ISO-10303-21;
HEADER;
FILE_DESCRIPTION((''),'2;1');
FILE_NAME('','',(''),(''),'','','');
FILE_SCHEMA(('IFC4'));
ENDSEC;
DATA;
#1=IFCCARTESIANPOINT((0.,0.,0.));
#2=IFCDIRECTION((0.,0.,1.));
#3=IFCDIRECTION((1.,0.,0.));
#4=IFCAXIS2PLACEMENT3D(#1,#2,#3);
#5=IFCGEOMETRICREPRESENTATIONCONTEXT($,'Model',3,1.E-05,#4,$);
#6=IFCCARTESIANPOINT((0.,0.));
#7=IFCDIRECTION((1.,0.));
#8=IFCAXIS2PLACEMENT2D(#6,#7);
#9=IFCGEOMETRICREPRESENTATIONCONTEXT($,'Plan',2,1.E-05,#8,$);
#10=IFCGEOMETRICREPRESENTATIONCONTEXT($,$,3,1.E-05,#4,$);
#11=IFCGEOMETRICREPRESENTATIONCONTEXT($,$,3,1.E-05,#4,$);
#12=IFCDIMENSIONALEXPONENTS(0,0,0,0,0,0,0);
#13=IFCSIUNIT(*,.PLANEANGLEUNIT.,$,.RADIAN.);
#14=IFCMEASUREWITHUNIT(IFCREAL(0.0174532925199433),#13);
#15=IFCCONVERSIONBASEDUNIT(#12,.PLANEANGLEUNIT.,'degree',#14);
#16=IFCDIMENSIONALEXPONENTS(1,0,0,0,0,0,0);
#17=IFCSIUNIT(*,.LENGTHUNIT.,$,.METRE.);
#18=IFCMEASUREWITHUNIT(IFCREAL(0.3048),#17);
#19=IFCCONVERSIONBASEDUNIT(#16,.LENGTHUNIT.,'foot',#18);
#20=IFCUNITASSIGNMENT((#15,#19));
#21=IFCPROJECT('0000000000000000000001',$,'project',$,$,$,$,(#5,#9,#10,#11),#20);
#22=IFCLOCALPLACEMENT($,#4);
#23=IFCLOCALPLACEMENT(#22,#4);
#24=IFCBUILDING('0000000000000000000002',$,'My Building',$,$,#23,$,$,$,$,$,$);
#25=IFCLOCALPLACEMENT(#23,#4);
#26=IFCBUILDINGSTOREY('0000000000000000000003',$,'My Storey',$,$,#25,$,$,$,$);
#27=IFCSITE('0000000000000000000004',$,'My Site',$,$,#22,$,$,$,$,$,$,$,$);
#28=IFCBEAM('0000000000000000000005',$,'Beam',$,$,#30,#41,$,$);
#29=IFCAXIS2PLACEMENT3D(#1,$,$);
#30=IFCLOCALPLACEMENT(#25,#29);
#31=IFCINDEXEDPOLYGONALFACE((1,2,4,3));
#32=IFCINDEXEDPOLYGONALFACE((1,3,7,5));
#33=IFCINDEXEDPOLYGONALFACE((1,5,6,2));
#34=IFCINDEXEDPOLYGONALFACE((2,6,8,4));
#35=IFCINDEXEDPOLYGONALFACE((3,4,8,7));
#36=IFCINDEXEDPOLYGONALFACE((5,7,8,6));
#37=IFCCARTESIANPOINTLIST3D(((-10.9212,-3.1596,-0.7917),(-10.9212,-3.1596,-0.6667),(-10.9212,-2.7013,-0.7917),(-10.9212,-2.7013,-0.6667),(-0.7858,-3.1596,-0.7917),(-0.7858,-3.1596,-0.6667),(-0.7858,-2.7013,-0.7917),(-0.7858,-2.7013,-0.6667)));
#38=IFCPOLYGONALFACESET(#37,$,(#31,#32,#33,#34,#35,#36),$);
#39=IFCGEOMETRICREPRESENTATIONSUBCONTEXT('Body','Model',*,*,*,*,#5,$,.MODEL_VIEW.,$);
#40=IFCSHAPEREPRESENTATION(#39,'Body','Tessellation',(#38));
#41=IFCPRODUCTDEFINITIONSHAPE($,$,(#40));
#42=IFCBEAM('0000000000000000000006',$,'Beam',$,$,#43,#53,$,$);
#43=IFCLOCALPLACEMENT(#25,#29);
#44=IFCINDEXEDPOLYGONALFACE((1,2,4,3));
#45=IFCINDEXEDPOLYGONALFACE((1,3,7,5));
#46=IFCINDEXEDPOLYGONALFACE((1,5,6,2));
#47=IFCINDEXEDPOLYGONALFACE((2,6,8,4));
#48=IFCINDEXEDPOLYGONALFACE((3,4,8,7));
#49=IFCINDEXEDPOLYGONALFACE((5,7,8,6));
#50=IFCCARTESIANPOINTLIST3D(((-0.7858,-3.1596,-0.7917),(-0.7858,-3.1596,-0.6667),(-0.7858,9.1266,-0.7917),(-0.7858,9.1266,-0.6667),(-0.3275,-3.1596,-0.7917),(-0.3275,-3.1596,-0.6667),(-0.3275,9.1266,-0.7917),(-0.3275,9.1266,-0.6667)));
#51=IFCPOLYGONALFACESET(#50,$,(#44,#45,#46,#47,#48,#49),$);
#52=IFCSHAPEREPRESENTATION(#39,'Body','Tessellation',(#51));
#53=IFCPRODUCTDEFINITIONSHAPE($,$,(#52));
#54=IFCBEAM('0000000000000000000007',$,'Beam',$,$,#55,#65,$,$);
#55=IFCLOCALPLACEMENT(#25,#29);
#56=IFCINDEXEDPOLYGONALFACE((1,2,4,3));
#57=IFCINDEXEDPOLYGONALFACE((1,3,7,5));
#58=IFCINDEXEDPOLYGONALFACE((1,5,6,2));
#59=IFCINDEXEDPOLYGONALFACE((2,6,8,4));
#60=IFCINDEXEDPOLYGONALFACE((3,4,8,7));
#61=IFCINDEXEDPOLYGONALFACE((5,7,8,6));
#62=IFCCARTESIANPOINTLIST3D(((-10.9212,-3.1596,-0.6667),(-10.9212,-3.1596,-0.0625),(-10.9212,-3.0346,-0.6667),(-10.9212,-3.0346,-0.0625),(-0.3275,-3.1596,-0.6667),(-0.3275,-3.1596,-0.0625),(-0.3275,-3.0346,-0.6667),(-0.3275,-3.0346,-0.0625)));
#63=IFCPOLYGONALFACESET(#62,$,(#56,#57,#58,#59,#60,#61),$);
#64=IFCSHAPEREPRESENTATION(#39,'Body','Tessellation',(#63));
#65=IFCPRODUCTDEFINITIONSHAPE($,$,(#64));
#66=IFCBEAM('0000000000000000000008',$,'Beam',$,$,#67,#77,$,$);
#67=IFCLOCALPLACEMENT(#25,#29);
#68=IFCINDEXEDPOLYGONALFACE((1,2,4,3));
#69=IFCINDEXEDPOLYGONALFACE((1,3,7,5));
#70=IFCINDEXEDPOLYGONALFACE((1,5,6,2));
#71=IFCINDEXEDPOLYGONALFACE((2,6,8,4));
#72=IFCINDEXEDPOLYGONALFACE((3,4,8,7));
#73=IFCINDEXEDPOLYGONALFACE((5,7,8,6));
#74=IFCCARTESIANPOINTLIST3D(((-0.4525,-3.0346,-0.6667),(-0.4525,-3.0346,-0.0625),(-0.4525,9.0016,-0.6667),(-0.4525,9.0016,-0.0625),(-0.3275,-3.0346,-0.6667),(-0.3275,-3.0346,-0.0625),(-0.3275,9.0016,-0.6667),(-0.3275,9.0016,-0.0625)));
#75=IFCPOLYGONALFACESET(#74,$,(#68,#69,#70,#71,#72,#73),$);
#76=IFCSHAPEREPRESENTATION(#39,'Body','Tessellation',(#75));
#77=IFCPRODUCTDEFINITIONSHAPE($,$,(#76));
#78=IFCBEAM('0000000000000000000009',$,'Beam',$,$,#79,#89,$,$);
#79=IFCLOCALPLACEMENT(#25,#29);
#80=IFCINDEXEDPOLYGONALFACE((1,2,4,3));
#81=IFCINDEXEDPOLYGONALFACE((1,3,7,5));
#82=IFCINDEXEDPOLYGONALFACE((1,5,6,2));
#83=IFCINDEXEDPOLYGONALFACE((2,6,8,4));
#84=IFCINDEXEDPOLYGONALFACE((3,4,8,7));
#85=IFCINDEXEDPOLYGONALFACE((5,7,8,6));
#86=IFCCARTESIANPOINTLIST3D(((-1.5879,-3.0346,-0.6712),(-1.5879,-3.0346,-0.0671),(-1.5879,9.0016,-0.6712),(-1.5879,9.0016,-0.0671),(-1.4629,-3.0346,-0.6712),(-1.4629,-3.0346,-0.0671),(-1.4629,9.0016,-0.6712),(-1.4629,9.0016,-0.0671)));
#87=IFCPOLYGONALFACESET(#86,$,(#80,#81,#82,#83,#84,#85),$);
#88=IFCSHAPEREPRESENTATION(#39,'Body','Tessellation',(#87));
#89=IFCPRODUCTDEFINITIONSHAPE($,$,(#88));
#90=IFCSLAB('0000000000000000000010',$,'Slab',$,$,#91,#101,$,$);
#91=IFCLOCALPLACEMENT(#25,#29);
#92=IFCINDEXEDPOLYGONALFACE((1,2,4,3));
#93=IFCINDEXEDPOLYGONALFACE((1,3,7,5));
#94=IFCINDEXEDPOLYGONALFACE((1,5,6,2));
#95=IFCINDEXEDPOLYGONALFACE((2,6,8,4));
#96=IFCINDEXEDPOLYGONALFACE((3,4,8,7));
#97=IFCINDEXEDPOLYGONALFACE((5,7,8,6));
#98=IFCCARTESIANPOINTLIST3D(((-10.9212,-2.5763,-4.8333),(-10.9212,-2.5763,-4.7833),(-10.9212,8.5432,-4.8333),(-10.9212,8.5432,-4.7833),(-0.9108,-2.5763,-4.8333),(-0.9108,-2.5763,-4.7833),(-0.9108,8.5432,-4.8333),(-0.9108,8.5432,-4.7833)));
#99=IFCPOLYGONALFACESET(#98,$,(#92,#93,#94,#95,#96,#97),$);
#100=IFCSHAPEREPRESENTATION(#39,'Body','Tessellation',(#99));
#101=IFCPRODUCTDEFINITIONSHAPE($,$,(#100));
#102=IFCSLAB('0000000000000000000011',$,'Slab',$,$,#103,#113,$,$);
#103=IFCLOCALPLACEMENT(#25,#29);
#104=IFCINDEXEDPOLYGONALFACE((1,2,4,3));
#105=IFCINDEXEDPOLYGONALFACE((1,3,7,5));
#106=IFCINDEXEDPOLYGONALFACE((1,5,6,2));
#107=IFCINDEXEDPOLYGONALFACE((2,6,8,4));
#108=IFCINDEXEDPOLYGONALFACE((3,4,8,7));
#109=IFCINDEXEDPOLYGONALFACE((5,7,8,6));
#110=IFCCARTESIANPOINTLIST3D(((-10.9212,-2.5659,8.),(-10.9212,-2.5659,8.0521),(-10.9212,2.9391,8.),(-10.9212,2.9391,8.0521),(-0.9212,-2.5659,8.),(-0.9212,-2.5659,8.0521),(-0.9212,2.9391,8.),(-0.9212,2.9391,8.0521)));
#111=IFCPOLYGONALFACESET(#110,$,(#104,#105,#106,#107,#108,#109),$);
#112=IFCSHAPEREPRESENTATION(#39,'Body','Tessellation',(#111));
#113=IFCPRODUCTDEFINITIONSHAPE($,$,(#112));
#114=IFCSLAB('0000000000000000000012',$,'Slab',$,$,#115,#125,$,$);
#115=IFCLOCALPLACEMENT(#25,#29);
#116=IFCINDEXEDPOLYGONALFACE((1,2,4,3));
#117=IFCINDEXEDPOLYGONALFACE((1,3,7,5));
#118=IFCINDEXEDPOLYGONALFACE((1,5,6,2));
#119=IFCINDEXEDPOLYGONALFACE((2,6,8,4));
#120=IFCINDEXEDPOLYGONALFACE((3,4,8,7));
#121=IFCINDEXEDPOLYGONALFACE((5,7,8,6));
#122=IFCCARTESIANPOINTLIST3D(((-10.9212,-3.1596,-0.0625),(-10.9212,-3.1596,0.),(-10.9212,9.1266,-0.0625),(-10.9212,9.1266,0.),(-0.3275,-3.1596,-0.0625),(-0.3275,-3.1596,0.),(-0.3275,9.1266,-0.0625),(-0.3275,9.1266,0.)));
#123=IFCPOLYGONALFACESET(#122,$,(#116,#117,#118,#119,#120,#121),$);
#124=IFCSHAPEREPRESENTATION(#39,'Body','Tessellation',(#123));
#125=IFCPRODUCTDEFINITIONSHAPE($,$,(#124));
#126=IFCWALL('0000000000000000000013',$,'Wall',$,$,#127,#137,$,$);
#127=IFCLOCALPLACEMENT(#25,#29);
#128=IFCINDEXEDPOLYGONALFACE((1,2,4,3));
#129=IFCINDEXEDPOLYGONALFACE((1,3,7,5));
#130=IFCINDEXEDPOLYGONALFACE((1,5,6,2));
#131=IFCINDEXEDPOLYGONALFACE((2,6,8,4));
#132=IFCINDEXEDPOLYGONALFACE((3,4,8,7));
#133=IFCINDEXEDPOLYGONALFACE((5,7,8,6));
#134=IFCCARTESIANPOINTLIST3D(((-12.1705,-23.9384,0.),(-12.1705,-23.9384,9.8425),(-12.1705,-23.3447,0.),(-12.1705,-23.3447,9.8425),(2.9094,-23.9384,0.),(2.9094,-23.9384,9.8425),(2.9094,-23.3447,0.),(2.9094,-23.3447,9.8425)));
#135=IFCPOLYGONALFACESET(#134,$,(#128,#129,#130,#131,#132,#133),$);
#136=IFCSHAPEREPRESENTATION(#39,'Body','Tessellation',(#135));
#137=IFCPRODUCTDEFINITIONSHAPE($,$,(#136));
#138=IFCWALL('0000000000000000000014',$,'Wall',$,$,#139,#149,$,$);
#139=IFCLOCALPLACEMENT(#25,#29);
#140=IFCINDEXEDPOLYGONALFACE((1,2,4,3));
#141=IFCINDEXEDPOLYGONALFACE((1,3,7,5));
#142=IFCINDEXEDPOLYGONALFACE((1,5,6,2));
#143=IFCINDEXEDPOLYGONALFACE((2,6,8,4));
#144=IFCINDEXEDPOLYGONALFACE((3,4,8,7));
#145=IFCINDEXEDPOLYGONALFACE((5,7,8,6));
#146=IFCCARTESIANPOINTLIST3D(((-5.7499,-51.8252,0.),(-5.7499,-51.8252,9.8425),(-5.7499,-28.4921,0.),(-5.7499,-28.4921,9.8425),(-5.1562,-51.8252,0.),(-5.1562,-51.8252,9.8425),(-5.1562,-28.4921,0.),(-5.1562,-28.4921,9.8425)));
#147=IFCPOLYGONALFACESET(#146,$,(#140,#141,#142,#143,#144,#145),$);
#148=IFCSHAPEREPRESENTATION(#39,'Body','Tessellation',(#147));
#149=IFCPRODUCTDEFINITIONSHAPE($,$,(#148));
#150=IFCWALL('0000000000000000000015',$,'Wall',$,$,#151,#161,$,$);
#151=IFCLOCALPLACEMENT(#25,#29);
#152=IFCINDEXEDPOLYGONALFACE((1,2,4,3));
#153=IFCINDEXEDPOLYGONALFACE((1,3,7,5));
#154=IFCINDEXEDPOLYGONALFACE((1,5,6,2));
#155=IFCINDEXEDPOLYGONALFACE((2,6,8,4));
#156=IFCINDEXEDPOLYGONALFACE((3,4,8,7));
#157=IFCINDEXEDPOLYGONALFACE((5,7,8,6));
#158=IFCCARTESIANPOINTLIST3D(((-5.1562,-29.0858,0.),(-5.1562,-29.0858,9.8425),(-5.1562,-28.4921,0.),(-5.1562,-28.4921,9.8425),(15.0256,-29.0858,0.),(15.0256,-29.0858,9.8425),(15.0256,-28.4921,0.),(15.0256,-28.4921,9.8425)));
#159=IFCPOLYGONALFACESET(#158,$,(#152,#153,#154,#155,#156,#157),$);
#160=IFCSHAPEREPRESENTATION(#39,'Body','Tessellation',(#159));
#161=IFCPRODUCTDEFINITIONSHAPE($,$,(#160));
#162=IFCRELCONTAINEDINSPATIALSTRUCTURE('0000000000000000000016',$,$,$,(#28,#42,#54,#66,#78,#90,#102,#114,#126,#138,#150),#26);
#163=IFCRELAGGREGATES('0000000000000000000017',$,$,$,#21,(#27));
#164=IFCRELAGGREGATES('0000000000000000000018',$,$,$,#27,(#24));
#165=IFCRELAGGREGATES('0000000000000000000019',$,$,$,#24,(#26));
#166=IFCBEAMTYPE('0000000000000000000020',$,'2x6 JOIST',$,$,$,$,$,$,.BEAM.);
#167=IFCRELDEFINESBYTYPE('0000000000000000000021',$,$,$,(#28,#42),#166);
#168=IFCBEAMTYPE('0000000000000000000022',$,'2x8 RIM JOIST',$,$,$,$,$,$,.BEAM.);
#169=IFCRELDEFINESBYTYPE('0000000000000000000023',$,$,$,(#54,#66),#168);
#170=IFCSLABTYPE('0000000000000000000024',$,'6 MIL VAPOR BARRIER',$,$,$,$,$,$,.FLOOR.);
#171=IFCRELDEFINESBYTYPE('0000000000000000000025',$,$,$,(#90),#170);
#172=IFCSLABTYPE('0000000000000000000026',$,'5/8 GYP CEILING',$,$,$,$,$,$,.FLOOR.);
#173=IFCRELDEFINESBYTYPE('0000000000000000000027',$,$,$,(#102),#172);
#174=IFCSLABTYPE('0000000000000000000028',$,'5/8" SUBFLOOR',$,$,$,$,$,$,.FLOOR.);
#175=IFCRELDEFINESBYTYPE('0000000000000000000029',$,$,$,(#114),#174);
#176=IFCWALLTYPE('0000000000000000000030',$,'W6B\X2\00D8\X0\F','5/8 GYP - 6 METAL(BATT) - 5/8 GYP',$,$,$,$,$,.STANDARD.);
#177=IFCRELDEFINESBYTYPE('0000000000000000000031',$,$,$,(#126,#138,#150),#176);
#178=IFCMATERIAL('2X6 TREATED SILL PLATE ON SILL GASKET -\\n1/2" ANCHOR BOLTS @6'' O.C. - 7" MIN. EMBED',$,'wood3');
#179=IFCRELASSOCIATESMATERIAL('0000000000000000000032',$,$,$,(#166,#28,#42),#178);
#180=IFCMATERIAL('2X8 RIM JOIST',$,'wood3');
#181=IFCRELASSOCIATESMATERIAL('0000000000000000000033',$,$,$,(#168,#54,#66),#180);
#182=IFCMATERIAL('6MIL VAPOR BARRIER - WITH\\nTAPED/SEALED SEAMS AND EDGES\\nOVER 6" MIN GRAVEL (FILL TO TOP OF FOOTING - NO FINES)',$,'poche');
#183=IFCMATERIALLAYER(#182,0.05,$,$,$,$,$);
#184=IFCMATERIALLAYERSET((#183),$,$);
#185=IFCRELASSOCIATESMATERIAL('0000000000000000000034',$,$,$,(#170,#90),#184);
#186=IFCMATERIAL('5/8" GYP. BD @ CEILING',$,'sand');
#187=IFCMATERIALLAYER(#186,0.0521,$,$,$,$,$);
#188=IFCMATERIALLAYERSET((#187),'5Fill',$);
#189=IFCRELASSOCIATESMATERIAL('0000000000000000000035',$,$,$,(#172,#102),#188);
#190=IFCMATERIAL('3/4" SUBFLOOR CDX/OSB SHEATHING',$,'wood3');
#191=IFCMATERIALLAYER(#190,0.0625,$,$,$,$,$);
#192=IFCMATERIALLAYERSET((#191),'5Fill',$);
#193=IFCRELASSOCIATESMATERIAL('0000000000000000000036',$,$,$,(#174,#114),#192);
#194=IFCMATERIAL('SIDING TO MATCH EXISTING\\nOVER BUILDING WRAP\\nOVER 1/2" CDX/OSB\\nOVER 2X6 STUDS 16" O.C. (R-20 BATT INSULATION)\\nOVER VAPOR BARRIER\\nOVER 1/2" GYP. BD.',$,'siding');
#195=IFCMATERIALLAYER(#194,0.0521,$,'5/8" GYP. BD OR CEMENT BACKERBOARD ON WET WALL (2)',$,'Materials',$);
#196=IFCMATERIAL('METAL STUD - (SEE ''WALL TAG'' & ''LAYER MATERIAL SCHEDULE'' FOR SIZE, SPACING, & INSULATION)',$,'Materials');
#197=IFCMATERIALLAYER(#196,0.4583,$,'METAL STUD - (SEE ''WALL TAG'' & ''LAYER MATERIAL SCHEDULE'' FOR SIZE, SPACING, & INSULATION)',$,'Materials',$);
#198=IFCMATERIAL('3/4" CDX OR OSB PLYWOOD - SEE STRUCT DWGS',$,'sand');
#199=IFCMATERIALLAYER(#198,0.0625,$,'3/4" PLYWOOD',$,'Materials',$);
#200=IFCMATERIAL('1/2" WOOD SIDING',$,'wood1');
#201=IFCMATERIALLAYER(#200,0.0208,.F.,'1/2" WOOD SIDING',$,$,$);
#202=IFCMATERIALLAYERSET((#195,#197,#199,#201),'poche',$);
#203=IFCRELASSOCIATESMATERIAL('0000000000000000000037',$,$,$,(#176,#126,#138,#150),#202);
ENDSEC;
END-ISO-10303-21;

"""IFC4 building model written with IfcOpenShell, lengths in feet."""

from ifc_helpers import new_model, entity, si_unit, converted_unit, frame, origin_with_axes, origin_2d_with_axis, place, context, subcontext, project, spatial, line, indexed_curve, rectangle, outline, extrude, material, layer, layer_set, layer_usage, material_profile, profile_set, profile_usage, type_object, element, save


model = new_model("IFC4")

# Units and contexts
model_context = context("Model", 3, precision=1e-05, world=origin_with_axes())
plan_context = context("Plan", 2, precision=1e-05, world=origin_2d_with_axis())
context_of_model_1 = context(None, 3, precision=1e-05, world=origin_with_axes())
context_of_model_2 = context(None, 3, precision=1e-05, world=origin_with_axes())
body_context = subcontext(model_context, "Body", "Model", "MODEL_VIEW")
ifc_project = project(units=[converted_unit("PLANEANGLEUNIT", "degree", entity("IfcReal", 0.0174532925199433), si_unit("PLANEANGLEUNIT", "RADIAN"), dimensions=[0, 0, 0, 0, 0, 0, 0]), converted_unit("LENGTHUNIT", "foot", entity("IfcReal", 0.3048), si_unit("LENGTHUNIT", "METRE"), dimensions=[1, 0, 0, 0, 0, 0, 0])], contexts=[model_context, plan_context, context_of_model_1, context_of_model_2])

# Site, building, storey
site_placement = place(None, origin_with_axes())
site = spatial("IfcSite", under=ifc_project, at=site_placement, Name="My Site")
building_placement = place(site_placement, origin_with_axes())
building = spatial("IfcBuilding", under=site, at=building_placement, Name="My Building")
storey_placement = place(building_placement, origin_with_axes())
storey = spatial("IfcBuildingStorey", under=building, at=storey_placement, Name="My Storey")

# Beams
ifc_material_1 = material(Name="2X6 TREATED SILL PLATE ON SILL GASKET -\\n1/2\" ANCHOR BOLTS @6' O.C. - 7\" MIN. EMBED", Category="wood3")
ifc_material_profile_1 = material_profile(ifc_material_1, rectangle(XDim=0.125, YDim=0.4583))
ifc_profile_set_1 = profile_set([ifc_material_profile_1])
ifc_profile_usage_1 = profile_usage(ifc_profile_set_1, cardinal=5)
beam_type_1 = type_object("IfcBeamType", Name="2x6 JOIST", PredefinedType="BEAM", material=ifc_profile_set_1)
beam_1_placement = place(storey_placement, frame((-10.9212, -2.9304, -0.7292), z_axis=(1.0, 0.0, 0.0), x_axis=(0.0, 0.0, 1.0)))
element("IfcBeam", 1, at=beam_1_placement, inside=storey, type_object=beam_type_1, material=ifc_profile_usage_1, Name="Beam", context=body_context, shape_type="SweptSolid", body=[
    extrude(rectangle(XDim=0.125, YDim=0.4583), origin_with_axes(), (0.0, 0.0, 1.0), 10.1354),
])
ifc_profile_usage_2 = profile_usage(ifc_profile_set_1, cardinal=5)
beam_2_placement = place(storey_placement, frame((-0.5566, -3.1596, -0.7292), z_axis=(0.0, 1.0, 0.0), x_axis=(0.0, 0.0, 1.0)))
element("IfcBeam", 2, at=beam_2_placement, inside=storey, type_object=beam_type_1, material=ifc_profile_usage_2, Name="Beam", context=body_context, shape_type="SweptSolid", body=[
    extrude(rectangle(XDim=0.125, YDim=0.4583), origin_with_axes(), (0.0, 0.0, 1.0), 12.2862),
])
ifc_material_2 = material(Name="2X8 RIM JOIST", Category="wood3")
ifc_material_profile_2 = material_profile(ifc_material_2, rectangle(XDim=0.125, YDim=0.6042))
ifc_profile_set_2 = profile_set([ifc_material_profile_2])
ifc_profile_usage_3 = profile_usage(ifc_profile_set_2)
beam_type_2 = type_object("IfcBeamType", Name="2x8 RIM JOIST", PredefinedType="BEAM", material=ifc_profile_set_2)
beam_3_placement = place(storey_placement, frame((-10.9212, -3.0971, -0.3646), z_axis=(1.0, 0.0, 0.0), x_axis=(0.0, 1.0, 0.0)))
element("IfcBeam", 3, at=beam_3_placement, inside=storey, type_object=beam_type_2, material=ifc_profile_usage_3, Name="Beam", context=body_context, shape_type="SweptSolid", body=[
    extrude(rectangle(XDim=0.125, YDim=0.6042), origin_with_axes(), (0.0, 0.0, 1.0), 10.5937),
])
ifc_profile_usage_4 = profile_usage(ifc_profile_set_2)
beam_4_placement = place(storey_placement, frame((-0.39, -3.0346, -0.3646), z_axis=(0.0, 1.0, 0.0), x_axis=(-1.0, 0.0, 0.0)))
element("IfcBeam", 4, at=beam_4_placement, inside=storey, type_object=beam_type_2, material=ifc_profile_usage_4, Name="Beam", context=body_context, shape_type="SweptSolid", body=[
    extrude(rectangle(XDim=0.125, YDim=0.6042), origin_with_axes(), (0.0, 0.0, 1.0), 12.0362),
])
beam_5_placement = place(storey_placement, frame((-1.5254, -3.0346, -0.3692), z_axis=(0.0, 1.0, 0.0), x_axis=(-1.0, 0.0, 0.0)))
element("IfcBeam", 5, at=beam_5_placement, inside=storey, Name="Beam", context=body_context, shape_type="SweptSolid", body=[
    extrude(rectangle(XDim=0.125, YDim=0.6042), origin_with_axes(), (0.0, 0.0, 1.0), 12.0362),
])

# Slabs
ifc_material_3 = material(Name="6MIL VAPOR BARRIER - WITH\\nTAPED/SEALED SEAMS AND EDGES\\nOVER 6\" MIN GRAVEL (FILL TO TOP OF FOOTING - NO FINES)", Category="poche")
ifc_layer_1 = layer(ifc_material_3, 0.05)
ifc_layer_set_1 = layer_set([ifc_layer_1])
ifc_layer_usage_1 = layer_usage(ifc_layer_set_1, "AXIS3", "POSITIVE", 0.0)
slab_type_1 = type_object("IfcSlabType", Name="6 MIL VAPOR BARRIER", PredefinedType="FLOOR", material=ifc_layer_set_1)
slab_1_placement = place(storey_placement, frame((-10.9212, -2.5763, -4.8333), z_axis=(0.0, 0.0, 1.0), x_axis=(1.0, 0.0, 0.0)))
element("IfcSlab", 6, at=slab_1_placement, inside=storey, type_object=slab_type_1, material=ifc_layer_usage_1, Name="Slab", context=body_context, shape_type="SweptSolid", body=[
    extrude(outline(indexed_curve([(10.0104, 11.1195), (10.0104, 0.0), (0.0, 0.0), (0.0, 11.1195)], segments=[line(3, 2), line(2, 1), line(1, 4), line(4, 3)], self_intersect=False)), None, (0.0, 0.0, 1.0), 0.05),
])
ifc_material_4 = material(Name="5/8\" GYP. BD @ CEILING", Category="sand")
ifc_layer_2 = layer(ifc_material_4, 0.0521)
ifc_layer_set_2 = layer_set([ifc_layer_2], Name="5Fill")
ifc_layer_usage_2 = layer_usage(ifc_layer_set_2, "AXIS3", "POSITIVE", 0.0)
slab_type_2 = type_object("IfcSlabType", Name="5/8 GYP CEILING", PredefinedType="FLOOR", material=ifc_layer_set_2)
slab_2_placement = place(storey_placement, frame((-10.9212, -2.5659, 8.0), z_axis=(0.0, 0.0, 1.0), x_axis=(1.0, 0.0, 0.0)))
element("IfcSlab", 7, at=slab_2_placement, inside=storey, type_object=slab_type_2, material=ifc_layer_usage_2, Name="Slab", context=body_context, shape_type="SweptSolid", body=[
    extrude(outline(indexed_curve([(0.0, 5.505), (0.0, 0.0), (10.0, 0.0), (10.0, 5.505)], segments=[line(3, 2), line(2, 1), line(1, 4), line(4, 3)], self_intersect=False)), None, (0.0, 0.0, 1.0), 0.0521),
])
ifc_material_5 = material(Name="3/4\" SUBFLOOR CDX/OSB SHEATHING", Category="wood3")
ifc_layer_3 = layer(ifc_material_5, 0.0625)
ifc_layer_set_3 = layer_set([ifc_layer_3], Name="5Fill")
ifc_layer_usage_3 = layer_usage(ifc_layer_set_3, "AXIS3", "POSITIVE", 0.0)
slab_type_3 = type_object("IfcSlabType", Name="5/8\" SUBFLOOR", PredefinedType="FLOOR", material=ifc_layer_set_3)
slab_3_placement = place(storey_placement, frame((-10.9212, -3.1596, -0.0625), z_axis=(0.0, 0.0, 1.0), x_axis=(1.0, 0.0, 0.0)))
element("IfcSlab", 8, at=slab_3_placement, inside=storey, type_object=slab_type_3, material=ifc_layer_usage_3, Name="Slab", context=body_context, shape_type="SweptSolid", body=[
    extrude(outline(indexed_curve([(0.0, 0.0), (10.5937, 0.0), (10.5937, 12.2862), (0.0, 12.2862)], segments=[line(3, 2), line(2, 1), line(1, 4), line(4, 3)], self_intersect=False)), None, (0.0, 0.0, 1.0), 0.0625),
])

# Shared definitions
ifc_material_6 = material(Name="SIDING TO MATCH EXISTING\\nOVER BUILDING WRAP\\nOVER 1/2\" CDX/OSB\\nOVER 2X6 STUDS 16\" O.C. (R-20 BATT INSULATION)\\nOVER VAPOR BARRIER\\nOVER 1/2\" GYP. BD.", Category="siding")
ifc_layer_4 = layer(ifc_material_6, 0.0521, Name="5/8\" GYP. BD OR CEMENT BACKERBOARD ON WET WALL (2)", Category="Materials")
ifc_material_7 = material(Name="METAL STUD - (SEE 'WALL TAG' & 'LAYER MATERIAL SCHEDULE' FOR SIZE, SPACING, & INSULATION)", Category="Materials")
ifc_layer_5 = layer(ifc_material_7, 0.4583, Name="METAL STUD - (SEE 'WALL TAG' & 'LAYER MATERIAL SCHEDULE' FOR SIZE, SPACING, & INSULATION)", Category="Materials")
ifc_material_8 = material(Name="3/4\" CDX OR OSB PLYWOOD - SEE STRUCT DWGS", Category="sand")
ifc_layer_6 = layer(ifc_material_8, 0.0625, Name="3/4\" PLYWOOD", Category="Materials")
ifc_material_9 = material(Name="1/2\" WOOD SIDING", Category="wood1")
ifc_layer_7 = layer(ifc_material_9, 0.0208, ventilated=False, Name="1/2\" WOOD SIDING")
ifc_layer_set_4 = layer_set([ifc_layer_4, ifc_layer_5, ifc_layer_6, ifc_layer_7], Name="poche")
wall_type_1 = type_object("IfcWallType", Name="W6BØF", Description="5/8 GYP - 6 METAL(BATT) - 5/8 GYP", PredefinedType="STANDARD", material=ifc_layer_set_4)

# Walls
ifc_layer_usage_4 = layer_usage(ifc_layer_set_4, "AXIS2", "POSITIVE", 0.0)
wall_1_placement = place(storey_placement, frame((2.9094, -23.3447, 0.0), z_axis=(0.0, 0.0, 1.0), x_axis=(-1.0, 0.0, 0.0)))
element("IfcWall", 9, at=wall_1_placement, inside=storey, type_object=wall_type_1, material=ifc_layer_usage_4, Name="Wall", context=body_context, shape_type="SweptSolid", body=[
    extrude(outline(indexed_curve([(0.0, 0.0), (0.0, 0.5937), (15.0799, 0.5937), (15.0799, 0.0), (0.0, 0.0)], self_intersect=False)), origin_with_axes(), (0.0, 0.0, 1.0), 9.8425),
])
ifc_layer_usage_5 = layer_usage(ifc_layer_set_4, "AXIS2", "POSITIVE", 0.0)
wall_2_placement = place(storey_placement, frame((-5.1562, -51.8252, 0.0), z_axis=(0.0, 0.0, 1.0), x_axis=(0.000001, 1.0, 0.0)))
element("IfcWall", 10, at=wall_2_placement, inside=storey, type_object=wall_type_1, material=ifc_layer_usage_5, Name="Wall", context=body_context, shape_type="SweptSolid", body=[
    extrude(outline(indexed_curve([(0.0, 0.0), (0.0, 0.5937), (23.3331, 0.5937), (23.3331, 0.0), (0.0, 0.0)], self_intersect=False)), origin_with_axes(), (0.0, 0.0, 1.0), 9.8425),
])
ifc_layer_usage_6 = layer_usage(ifc_layer_set_4, "AXIS2", "POSITIVE", 0.0)
wall_3_placement = place(storey_placement, frame((-5.1562, -29.0858, 0.0), z_axis=(0.0, 0.0, 1.0), x_axis=(1.0, 0.0, 0.0)))
element("IfcWall", 11, at=wall_3_placement, inside=storey, type_object=wall_type_1, material=ifc_layer_usage_6, Name="Wall", context=body_context, shape_type="SweptSolid", body=[
    extrude(outline(indexed_curve([(0.0, 0.0), (0.0, 0.5937), (20.1818, 0.5937), (20.1818, 0.0), (0.0, 0.0)], self_intersect=False)), origin_with_axes(), (0.0, 0.0, 1.0), 9.8425),
])

save(model, "model.ifc")
